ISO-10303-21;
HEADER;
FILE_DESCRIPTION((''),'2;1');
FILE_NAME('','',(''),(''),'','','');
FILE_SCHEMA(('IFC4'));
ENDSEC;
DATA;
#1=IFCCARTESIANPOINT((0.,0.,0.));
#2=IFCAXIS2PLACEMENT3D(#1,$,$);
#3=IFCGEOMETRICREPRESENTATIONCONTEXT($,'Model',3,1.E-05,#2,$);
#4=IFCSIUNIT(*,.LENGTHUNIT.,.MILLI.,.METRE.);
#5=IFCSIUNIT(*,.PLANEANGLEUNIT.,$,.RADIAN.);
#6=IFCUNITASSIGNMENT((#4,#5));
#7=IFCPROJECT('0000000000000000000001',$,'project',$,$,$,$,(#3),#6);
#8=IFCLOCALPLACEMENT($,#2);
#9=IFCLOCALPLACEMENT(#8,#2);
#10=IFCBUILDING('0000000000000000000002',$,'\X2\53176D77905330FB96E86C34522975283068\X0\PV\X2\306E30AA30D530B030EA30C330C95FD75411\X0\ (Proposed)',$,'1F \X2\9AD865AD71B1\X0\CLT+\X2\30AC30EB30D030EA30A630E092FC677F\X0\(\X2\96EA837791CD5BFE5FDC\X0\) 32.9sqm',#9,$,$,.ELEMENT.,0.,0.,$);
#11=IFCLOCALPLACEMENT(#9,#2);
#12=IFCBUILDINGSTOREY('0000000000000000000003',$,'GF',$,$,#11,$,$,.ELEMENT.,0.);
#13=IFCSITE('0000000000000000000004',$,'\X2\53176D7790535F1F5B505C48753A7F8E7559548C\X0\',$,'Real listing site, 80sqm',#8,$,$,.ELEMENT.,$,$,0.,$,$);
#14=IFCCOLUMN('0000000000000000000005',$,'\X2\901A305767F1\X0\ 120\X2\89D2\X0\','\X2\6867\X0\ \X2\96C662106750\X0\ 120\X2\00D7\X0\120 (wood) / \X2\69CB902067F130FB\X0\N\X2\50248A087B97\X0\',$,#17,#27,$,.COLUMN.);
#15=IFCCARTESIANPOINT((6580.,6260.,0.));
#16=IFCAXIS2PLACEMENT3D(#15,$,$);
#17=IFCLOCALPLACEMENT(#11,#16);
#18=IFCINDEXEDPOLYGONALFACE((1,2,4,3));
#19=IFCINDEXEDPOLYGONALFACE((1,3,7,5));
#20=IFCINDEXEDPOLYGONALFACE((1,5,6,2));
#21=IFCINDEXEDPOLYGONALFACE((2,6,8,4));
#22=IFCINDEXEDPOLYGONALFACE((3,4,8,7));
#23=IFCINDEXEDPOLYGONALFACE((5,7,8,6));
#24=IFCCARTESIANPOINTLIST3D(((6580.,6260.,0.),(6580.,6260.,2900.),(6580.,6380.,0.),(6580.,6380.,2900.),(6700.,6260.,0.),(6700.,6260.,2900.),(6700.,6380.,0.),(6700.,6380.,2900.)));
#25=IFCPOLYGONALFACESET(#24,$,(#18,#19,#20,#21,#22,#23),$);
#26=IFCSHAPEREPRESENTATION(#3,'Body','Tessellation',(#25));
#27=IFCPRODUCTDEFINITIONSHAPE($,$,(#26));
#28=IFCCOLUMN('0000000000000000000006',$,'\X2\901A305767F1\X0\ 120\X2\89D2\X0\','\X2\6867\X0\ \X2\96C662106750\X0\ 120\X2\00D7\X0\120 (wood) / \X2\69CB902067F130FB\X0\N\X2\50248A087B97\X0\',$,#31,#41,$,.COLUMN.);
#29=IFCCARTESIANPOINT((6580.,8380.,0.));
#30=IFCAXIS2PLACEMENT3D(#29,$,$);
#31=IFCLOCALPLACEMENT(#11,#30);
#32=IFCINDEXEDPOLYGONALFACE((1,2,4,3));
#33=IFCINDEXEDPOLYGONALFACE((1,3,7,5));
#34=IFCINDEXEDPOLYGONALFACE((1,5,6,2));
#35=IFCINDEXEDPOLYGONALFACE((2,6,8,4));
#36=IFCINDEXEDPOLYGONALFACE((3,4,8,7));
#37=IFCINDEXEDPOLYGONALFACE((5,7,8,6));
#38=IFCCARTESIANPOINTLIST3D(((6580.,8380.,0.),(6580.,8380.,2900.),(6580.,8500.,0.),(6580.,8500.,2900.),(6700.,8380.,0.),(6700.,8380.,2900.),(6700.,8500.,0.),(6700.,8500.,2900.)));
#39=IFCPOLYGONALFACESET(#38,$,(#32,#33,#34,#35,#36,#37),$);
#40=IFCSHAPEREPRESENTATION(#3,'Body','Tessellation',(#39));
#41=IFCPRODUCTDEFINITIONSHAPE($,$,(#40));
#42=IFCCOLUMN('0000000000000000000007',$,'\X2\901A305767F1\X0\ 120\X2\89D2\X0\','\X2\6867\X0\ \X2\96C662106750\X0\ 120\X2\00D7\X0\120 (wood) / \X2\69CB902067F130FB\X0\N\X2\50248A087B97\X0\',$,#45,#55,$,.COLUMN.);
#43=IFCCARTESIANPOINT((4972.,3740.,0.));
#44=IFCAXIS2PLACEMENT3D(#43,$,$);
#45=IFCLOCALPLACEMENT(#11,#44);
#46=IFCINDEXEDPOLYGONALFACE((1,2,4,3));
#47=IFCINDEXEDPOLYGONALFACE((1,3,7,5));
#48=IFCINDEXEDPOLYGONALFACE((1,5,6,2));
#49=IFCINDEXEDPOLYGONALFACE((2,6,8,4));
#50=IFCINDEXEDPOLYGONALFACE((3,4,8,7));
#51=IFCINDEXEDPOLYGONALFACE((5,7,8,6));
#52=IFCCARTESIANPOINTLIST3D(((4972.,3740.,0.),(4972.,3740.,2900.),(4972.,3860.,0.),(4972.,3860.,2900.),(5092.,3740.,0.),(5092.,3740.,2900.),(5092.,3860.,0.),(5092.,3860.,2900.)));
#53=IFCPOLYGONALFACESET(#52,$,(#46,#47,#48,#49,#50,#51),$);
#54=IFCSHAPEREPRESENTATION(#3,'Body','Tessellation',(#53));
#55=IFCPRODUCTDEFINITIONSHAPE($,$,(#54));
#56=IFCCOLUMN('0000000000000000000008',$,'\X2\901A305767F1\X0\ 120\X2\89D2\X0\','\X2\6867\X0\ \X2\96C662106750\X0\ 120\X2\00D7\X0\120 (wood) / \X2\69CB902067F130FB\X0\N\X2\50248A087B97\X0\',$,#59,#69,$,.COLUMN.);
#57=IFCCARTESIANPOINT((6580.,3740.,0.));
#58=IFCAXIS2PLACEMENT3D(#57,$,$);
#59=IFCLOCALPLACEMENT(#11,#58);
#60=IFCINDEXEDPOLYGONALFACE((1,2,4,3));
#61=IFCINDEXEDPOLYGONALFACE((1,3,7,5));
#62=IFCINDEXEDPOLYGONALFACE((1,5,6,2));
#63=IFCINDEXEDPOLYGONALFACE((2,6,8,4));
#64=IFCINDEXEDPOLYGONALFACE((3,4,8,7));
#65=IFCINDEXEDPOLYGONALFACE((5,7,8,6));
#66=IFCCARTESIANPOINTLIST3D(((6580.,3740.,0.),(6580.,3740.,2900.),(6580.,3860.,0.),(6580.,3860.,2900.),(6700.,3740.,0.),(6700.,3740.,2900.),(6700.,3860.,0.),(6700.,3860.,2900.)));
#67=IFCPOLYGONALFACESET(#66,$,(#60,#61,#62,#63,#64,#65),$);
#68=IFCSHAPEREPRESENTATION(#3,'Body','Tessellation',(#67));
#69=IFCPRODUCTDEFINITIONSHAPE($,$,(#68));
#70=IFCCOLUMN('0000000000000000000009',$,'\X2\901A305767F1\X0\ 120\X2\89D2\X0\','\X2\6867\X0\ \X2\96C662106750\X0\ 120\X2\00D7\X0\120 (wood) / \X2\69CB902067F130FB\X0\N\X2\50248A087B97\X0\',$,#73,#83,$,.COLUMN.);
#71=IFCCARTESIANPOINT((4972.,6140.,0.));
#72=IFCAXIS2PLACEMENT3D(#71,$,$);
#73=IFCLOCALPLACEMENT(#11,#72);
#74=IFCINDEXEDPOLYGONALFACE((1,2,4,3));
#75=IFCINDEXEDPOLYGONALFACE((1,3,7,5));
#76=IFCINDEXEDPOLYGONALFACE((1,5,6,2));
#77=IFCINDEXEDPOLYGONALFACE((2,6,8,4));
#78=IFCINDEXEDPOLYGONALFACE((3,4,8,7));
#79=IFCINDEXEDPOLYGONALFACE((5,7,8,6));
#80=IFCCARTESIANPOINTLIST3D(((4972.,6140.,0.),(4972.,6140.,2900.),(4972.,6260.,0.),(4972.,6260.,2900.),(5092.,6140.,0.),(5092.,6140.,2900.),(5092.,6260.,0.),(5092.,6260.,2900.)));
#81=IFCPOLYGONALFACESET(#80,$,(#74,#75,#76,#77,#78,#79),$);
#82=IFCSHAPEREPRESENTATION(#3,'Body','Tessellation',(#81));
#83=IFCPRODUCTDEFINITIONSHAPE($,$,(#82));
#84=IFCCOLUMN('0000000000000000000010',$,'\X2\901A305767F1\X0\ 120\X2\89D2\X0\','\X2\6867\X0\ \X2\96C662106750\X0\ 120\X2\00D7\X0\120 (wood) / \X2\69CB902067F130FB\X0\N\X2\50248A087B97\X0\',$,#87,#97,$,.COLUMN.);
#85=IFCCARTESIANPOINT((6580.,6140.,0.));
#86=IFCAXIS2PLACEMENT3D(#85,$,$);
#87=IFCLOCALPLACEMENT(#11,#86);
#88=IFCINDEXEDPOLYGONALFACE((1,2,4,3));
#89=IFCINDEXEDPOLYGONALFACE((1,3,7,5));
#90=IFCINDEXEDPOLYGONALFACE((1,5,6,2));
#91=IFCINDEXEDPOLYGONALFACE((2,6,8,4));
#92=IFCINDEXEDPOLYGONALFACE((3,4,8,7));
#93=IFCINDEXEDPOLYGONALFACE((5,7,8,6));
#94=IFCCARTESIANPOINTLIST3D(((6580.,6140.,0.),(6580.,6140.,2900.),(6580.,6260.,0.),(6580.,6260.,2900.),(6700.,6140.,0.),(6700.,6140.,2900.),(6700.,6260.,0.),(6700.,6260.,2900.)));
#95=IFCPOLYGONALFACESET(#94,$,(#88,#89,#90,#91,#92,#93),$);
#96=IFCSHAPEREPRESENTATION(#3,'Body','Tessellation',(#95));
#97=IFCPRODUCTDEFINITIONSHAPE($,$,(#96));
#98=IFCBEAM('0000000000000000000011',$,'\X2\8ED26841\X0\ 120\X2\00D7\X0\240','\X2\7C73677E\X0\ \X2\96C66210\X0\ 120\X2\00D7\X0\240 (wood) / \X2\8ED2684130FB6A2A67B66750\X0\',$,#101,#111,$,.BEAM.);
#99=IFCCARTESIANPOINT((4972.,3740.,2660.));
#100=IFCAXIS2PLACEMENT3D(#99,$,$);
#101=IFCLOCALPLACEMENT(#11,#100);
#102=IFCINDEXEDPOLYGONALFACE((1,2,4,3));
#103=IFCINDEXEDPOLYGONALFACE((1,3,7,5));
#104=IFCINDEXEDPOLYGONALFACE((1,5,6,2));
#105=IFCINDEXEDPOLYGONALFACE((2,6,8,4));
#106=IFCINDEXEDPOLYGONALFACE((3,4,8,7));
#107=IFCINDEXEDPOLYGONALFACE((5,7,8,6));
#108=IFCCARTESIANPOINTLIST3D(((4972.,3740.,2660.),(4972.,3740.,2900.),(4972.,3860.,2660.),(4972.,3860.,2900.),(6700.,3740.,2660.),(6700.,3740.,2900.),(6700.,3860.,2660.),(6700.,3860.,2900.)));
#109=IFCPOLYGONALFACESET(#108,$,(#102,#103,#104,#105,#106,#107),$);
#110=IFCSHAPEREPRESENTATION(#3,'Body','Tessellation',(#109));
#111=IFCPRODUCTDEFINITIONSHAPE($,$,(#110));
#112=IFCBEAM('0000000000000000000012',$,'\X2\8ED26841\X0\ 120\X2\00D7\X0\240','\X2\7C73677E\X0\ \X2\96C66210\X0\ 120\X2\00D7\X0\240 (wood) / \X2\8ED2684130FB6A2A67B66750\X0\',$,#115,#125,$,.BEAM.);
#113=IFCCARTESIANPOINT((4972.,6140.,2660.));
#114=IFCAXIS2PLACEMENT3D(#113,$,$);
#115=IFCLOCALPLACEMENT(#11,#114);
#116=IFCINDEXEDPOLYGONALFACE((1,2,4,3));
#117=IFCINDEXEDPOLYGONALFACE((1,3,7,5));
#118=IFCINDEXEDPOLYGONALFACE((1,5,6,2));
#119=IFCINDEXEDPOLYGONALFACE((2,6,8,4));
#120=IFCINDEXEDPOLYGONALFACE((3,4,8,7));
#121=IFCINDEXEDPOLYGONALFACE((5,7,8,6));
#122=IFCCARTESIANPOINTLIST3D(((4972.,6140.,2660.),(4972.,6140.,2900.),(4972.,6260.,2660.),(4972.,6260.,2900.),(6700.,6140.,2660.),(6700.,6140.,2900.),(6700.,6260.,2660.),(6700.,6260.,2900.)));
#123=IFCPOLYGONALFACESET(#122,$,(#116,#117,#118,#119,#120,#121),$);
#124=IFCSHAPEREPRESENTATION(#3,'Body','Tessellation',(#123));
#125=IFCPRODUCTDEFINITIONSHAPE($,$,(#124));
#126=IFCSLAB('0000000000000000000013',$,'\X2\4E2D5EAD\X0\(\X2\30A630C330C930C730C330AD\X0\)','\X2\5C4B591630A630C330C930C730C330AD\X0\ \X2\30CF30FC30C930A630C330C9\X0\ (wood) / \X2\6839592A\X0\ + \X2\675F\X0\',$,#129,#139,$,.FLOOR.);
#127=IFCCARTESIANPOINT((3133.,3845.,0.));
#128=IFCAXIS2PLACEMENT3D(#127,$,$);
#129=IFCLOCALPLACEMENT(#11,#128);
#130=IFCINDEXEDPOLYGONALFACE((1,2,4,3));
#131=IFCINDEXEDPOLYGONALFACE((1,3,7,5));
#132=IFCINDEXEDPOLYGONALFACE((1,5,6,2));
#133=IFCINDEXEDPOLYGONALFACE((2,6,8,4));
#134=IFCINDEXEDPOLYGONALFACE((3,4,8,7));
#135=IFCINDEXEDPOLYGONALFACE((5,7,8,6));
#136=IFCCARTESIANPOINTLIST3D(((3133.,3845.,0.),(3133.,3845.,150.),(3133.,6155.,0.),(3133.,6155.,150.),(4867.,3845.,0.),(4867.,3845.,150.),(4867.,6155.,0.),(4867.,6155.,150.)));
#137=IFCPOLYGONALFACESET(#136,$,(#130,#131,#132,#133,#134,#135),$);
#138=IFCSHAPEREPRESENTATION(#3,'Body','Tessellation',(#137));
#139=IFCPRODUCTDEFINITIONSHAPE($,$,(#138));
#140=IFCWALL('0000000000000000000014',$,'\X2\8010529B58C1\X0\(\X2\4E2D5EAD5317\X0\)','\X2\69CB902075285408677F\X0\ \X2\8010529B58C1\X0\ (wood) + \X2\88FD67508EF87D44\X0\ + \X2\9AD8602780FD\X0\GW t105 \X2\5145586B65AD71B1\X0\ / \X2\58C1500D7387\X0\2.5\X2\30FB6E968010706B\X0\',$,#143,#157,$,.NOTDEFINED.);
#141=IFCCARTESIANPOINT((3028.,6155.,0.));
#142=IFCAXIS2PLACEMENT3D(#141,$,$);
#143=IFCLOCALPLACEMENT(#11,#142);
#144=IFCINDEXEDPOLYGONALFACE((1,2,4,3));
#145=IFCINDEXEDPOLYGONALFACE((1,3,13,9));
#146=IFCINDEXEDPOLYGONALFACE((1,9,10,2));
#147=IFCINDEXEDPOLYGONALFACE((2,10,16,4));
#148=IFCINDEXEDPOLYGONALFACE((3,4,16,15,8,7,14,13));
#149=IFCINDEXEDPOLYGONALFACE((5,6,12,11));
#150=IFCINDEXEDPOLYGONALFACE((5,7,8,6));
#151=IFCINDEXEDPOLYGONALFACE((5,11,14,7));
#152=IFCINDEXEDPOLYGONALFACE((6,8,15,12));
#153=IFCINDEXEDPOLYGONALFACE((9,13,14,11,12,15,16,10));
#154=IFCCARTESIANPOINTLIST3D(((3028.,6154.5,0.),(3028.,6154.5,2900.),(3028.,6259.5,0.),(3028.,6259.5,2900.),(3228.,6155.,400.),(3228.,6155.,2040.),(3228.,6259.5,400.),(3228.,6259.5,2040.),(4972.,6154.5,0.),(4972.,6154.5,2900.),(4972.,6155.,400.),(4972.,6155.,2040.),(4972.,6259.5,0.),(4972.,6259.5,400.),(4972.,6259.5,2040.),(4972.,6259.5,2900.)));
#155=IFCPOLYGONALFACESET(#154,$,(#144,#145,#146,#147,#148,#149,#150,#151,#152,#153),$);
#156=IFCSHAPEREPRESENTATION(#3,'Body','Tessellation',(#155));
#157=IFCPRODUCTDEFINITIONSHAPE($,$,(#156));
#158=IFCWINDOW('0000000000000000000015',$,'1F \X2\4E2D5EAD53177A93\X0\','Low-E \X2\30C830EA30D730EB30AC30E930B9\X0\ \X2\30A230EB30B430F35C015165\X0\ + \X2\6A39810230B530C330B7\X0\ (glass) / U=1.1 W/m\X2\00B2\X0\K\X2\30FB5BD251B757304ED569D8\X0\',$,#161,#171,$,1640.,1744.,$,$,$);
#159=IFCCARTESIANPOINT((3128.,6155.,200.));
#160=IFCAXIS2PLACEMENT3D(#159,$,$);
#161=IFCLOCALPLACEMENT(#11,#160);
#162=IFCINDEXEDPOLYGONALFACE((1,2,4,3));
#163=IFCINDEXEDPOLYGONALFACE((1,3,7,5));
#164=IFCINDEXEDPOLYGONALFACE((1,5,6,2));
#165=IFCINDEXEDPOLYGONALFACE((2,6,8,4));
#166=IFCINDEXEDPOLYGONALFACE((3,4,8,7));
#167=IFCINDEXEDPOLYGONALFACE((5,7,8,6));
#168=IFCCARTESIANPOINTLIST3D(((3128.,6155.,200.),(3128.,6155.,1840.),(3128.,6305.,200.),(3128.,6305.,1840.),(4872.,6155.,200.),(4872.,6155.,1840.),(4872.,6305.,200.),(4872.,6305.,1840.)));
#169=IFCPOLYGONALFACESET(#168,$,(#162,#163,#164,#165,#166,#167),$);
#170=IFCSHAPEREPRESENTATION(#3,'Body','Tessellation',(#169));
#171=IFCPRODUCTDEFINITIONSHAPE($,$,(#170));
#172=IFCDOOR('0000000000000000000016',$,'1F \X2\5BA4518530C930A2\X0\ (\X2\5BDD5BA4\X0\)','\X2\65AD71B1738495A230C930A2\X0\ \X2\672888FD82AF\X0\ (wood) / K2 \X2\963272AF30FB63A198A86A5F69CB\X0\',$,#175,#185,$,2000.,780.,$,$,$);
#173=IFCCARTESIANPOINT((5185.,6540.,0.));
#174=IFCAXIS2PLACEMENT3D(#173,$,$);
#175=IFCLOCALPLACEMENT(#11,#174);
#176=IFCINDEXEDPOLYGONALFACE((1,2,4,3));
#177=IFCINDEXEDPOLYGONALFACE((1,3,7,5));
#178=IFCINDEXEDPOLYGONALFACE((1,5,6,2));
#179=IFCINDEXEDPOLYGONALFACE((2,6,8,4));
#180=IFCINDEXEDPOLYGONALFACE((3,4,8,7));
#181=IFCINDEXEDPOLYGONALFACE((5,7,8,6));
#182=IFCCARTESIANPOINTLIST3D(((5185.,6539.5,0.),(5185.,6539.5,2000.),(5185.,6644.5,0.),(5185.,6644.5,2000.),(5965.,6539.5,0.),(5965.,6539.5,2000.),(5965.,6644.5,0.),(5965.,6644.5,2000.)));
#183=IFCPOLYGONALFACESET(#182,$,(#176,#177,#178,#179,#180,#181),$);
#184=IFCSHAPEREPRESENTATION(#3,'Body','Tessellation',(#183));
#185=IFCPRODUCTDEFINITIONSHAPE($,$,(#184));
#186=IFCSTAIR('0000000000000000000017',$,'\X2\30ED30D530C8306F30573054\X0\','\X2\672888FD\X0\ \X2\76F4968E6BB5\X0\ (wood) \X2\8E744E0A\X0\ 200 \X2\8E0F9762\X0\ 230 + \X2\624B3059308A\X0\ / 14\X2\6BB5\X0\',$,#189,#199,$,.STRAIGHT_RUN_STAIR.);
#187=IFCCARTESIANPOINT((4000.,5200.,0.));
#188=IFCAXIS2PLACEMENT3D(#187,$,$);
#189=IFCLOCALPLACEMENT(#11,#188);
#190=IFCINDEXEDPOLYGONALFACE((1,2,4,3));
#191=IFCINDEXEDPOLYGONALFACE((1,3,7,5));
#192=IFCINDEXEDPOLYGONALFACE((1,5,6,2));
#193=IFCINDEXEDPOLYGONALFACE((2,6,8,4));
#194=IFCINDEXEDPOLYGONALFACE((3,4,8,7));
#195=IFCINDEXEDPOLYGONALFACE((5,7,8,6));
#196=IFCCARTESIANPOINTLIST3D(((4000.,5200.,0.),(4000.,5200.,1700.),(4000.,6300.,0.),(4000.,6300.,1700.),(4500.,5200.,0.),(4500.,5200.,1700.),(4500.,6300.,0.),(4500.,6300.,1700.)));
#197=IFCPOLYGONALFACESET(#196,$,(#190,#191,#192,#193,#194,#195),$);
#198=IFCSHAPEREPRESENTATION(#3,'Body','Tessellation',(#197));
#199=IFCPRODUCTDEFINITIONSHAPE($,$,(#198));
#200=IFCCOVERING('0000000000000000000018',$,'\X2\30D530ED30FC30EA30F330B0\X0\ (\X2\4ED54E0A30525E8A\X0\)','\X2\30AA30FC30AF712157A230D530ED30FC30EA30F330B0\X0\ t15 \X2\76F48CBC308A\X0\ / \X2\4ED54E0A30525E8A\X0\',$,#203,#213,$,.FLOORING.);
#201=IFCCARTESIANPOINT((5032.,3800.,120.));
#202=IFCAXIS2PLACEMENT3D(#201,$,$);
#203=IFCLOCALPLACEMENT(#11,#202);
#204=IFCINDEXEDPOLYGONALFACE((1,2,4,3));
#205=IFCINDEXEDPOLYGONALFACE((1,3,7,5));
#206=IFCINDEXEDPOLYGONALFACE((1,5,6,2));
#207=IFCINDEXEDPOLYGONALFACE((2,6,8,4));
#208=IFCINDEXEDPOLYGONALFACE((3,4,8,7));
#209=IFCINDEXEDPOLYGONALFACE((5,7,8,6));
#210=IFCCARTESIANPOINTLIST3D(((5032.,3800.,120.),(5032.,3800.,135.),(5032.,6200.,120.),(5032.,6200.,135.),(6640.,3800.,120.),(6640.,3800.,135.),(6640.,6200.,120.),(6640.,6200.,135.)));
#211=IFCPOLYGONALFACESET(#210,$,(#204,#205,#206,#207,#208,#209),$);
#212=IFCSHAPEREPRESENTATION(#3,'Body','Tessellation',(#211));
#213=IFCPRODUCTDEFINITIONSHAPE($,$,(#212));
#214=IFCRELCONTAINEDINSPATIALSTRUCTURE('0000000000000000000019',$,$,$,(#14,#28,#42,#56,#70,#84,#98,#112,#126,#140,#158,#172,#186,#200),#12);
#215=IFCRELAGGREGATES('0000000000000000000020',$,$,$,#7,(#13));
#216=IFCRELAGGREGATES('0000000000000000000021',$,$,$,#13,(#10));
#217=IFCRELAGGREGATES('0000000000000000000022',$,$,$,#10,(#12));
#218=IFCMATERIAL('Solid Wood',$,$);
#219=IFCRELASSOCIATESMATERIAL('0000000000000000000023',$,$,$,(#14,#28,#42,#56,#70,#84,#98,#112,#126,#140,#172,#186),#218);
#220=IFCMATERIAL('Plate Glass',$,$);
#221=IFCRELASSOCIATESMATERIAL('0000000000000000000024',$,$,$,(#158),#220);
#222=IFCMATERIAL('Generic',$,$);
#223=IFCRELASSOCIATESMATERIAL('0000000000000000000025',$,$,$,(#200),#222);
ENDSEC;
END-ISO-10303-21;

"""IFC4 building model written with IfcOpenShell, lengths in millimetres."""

from ifc_helpers import new_model, si_unit, frame, frame_2d, origin, place, context, project, spatial, rectangle, extrude, material, element, fill, save


model = new_model("IFC4")

# Units and contexts
model_context = context("Model", 3, precision=1e-05, world=origin())
ifc_project = project(units=[si_unit("LENGTHUNIT", "METRE", prefix="MILLI"), si_unit("PLANEANGLEUNIT", "RADIAN")], contexts=[model_context])

# Site, building, storey
site_placement = place(None, origin())
site = spatial("IfcSite", under=ifc_project, at=site_placement, Name="北海道弟子屈町美留和", ObjectType="Real listing site, 80sqm", CompositionType="ELEMENT", RefElevation=0.0)
building_placement = place(site_placement, origin())
building = spatial("IfcBuilding", under=site, at=building_placement, Name="北海道・雨水利用とPVのオフグリッド志向 (Proposed)", ObjectType="1F 高断熱CLT+ガルバリウム鋼板(雪荷重対応) 32.9sqm", CompositionType="ELEMENT", ElevationOfRefHeight=0.0, ElevationOfTerrain=0.0)
storey_placement = place(building_placement, origin())
storey = spatial("IfcBuildingStorey", under=building, at=storey_placement, Name="GF", CompositionType="ELEMENT", Elevation=0.0)

# Columns
ifc_material_1 = material(Name="Solid Wood")
column_1_placement = place(storey_placement, frame((6580.0, 6260.0, 0.0)))
element("IfcColumn", 1, at=column_1_placement, inside=storey, material=ifc_material_1, Name="通し柱 120角", Description="桧 集成材 120×120 (wood) / 構造柱・N値計算", PredefinedType="COLUMN", context=model_context, shape_type="SweptSolid", body=[
    extrude(rectangle(XDim=120.0, YDim=120.0, at=frame_2d((60.0, 60.0))), frame((6580.0, 6260.0, 0.0)), (0.0, 0.0, 1.0), 2900.0),
])
column_2_placement = place(storey_placement, frame((6580.0, 8380.0, 0.0)))
element("IfcColumn", 2, at=column_2_placement, inside=storey, material=ifc_material_1, Name="通し柱 120角", Description="桧 集成材 120×120 (wood) / 構造柱・N値計算", PredefinedType="COLUMN", context=model_context, shape_type="SweptSolid", body=[
    extrude(rectangle(XDim=120.0, YDim=120.0, at=frame_2d((60.0, 60.0))), frame((6580.0, 8380.0, 0.0)), (0.0, 0.0, 1.0), 2900.0),
])
column_3_placement = place(storey_placement, frame((4972.0, 3740.0, 0.0)))
element("IfcColumn", 3, at=column_3_placement, inside=storey, material=ifc_material_1, Name="通し柱 120角", Description="桧 集成材 120×120 (wood) / 構造柱・N値計算", PredefinedType="COLUMN", context=model_context, shape_type="SweptSolid", body=[
    extrude(rectangle(XDim=120.0, YDim=120.0, at=frame_2d((60.0, 60.0))), frame((4972.0, 3740.0, 0.0)), (0.0, 0.0, 1.0), 2900.0),
])
column_4_placement = place(storey_placement, frame((6580.0, 3740.0, 0.0)))
element("IfcColumn", 4, at=column_4_placement, inside=storey, material=ifc_material_1, Name="通し柱 120角", Description="桧 集成材 120×120 (wood) / 構造柱・N値計算", PredefinedType="COLUMN", context=model_context, shape_type="SweptSolid", body=[
    extrude(rectangle(XDim=120.0, YDim=120.0, at=frame_2d((60.0, 60.0))), frame((6580.0, 3740.0, 0.0)), (0.0, 0.0, 1.0), 2900.0),
])
column_5_placement = place(storey_placement, frame((4972.0, 6140.0, 0.0)))
element("IfcColumn", 5, at=column_5_placement, inside=storey, material=ifc_material_1, Name="通し柱 120角", Description="桧 集成材 120×120 (wood) / 構造柱・N値計算", PredefinedType="COLUMN", context=model_context, shape_type="SweptSolid", body=[
    extrude(rectangle(XDim=120.0, YDim=120.0, at=frame_2d((60.0, 60.0))), frame((4972.0, 6140.0, 0.0)), (0.0, 0.0, 1.0), 2900.0),
])
column_6_placement = place(storey_placement, frame((6580.0, 6140.0, 0.0)))
element("IfcColumn", 6, at=column_6_placement, inside=storey, material=ifc_material_1, Name="通し柱 120角", Description="桧 集成材 120×120 (wood) / 構造柱・N値計算", PredefinedType="COLUMN", context=model_context, shape_type="SweptSolid", body=[
    extrude(rectangle(XDim=120.0, YDim=120.0, at=frame_2d((60.0, 60.0))), frame((6580.0, 6140.0, 0.0)), (0.0, 0.0, 1.0), 2900.0),
])

# Beams
beam_1_placement = place(storey_placement, frame((4972.0, 3740.0, 2660.0)))
element("IfcBeam", 7, at=beam_1_placement, inside=storey, material=ifc_material_1, Name="軒桁 120×240", Description="米松 集成 120×240 (wood) / 軒桁・横架材", PredefinedType="BEAM", context=model_context, shape_type="SweptSolid", body=[
    extrude(rectangle(XDim=1728.0, YDim=120.0, at=frame_2d((864.0, 60.0))), frame((4972.0, 3740.0, 2660.0)), (0.0, 0.0, 1.0), 240.0),
])
beam_2_placement = place(storey_placement, frame((4972.0, 6140.0, 2660.0)))
element("IfcBeam", 8, at=beam_2_placement, inside=storey, material=ifc_material_1, Name="軒桁 120×240", Description="米松 集成 120×240 (wood) / 軒桁・横架材", PredefinedType="BEAM", context=model_context, shape_type="SweptSolid", body=[
    extrude(rectangle(XDim=1728.0, YDim=120.0, at=frame_2d((864.0, 60.0))), frame((4972.0, 6140.0, 2660.0)), (0.0, 0.0, 1.0), 240.0),
])

# Slab
slab_placement = place(storey_placement, frame((3133.0, 3845.0, 0.0)))
element("IfcSlab", 9, at=slab_placement, inside=storey, material=ifc_material_1, Name="中庭(ウッドデッキ)", Description="屋外ウッドデッキ ハードウッド (wood) / 根太 + 束", PredefinedType="FLOOR", context=model_context, shape_type="SweptSolid", body=[
    extrude(rectangle(XDim=1734.0, YDim=2310.0, at=frame_2d((867.0, 1155.0))), frame((3133.0, 3845.0, 0.0)), (0.0, 0.0, 1.0), 150.0),
])

# Wall, opening, window
wall_1_placement = place(storey_placement, frame((3028.0, 6155.0, 0.0)))
wall_1 = element("IfcWall", 10, at=wall_1_placement, inside=storey, material=ifc_material_1, Name="耐力壁(中庭北)", Description="構造用合板 耐力壁 (wood) + 製材軸組 + 高性能GW t105 充填断熱 / 壁倍率2.5・準耐火", PredefinedType="NOTDEFINED", context=model_context, shape_type="SweptSolid", body=[
    extrude(rectangle(XDim=1944.0, YDim=105.0, at=frame_2d((972.0, 52.0))), frame((3028.0, 6155.0, 0.0)), (0.0, 0.0, 1.0), 2900.0),
])
opening_placement = place(storey_placement, frame((3128.0, 6155.0, 200.0)))
opening = element("IfcOpeningElement", 11, at=opening_placement, cuts=wall_1, PredefinedType="NOTDEFINED", context=model_context, shape_type="SweptSolid", body=[
    extrude(rectangle(XDim=1744.0, YDim=150.0, at=frame_2d((872.0, 75.0))), frame((3128.0, 6155.0, 200.0)), (0.0, 0.0, 1.0), 1640.0),
])
ifc_material_2 = material(Name="Plate Glass")
window_placement = place(storey_placement, frame((3128.0, 6155.0, 200.0)))
window = element("IfcWindow", 12, at=window_placement, inside=storey, material=ifc_material_2, Name="1F 中庭北窓", Description="Low-E トリプルガラス アルゴン封入 + 樹脂サッシ (glass) / U=1.1 W/m²K・寒冷地仕様", OverallHeight=1640.0, OverallWidth=1744.0, context=model_context, shape_type="SweptSolid", body=[
    extrude(rectangle(XDim=1744.0, YDim=150.0, at=frame_2d((872.0, 75.0))), frame((3128.0, 6155.0, 200.0)), (0.0, 0.0, 1.0), 1640.0),
])
fill(opening, window)

# Door
door_placement = place(storey_placement, frame((5185.0, 6540.0, 0.0)))
element("IfcDoor", 13, at=door_placement, inside=storey, material=ifc_material_1, Name="1F 室内ドア (寝室)", Description="断熱玄関ドア 木製芯 (wood) / K2 防犯・採風機構", OverallHeight=2000.0, OverallWidth=780.0, context=model_context, shape_type="SweptSolid", body=[
    extrude(rectangle(XDim=780.0, YDim=105.0, at=frame_2d((390.0, 52.0))), frame((5185.0, 6540.0, 0.0)), (0.0, 0.0, 1.0), 2000.0),
])

# Stair
stair_placement = place(storey_placement, frame((4000.0, 5200.0, 0.0)))
element("IfcStair", 14, at=stair_placement, inside=storey, material=ifc_material_1, Name="ロフトはしご", Description="木製 直階段 (wood) 蹴上 200 踏面 230 + 手すり / 14段", PredefinedType="STRAIGHT_RUN_STAIR", context=model_context, shape_type="SweptSolid", body=[
    extrude(rectangle(XDim=500.0, YDim=1100.0, at=frame_2d((250.0, 550.0))), frame((4000.0, 5200.0, 0.0)), (0.0, 0.0, 1.0), 1700.0),
])

# Covering
ifc_material_3 = material(Name="Generic")
covering_placement = place(storey_placement, frame((5032.0, 3800.0, 120.0)))
element("IfcCovering", 15, at=covering_placement, inside=storey, material=ifc_material_3, Name="フローリング (仕上げ床)", Description="オーク無垢フローリング t15 直貼り / 仕上げ床", PredefinedType="FLOORING", context=model_context, shape_type="SweptSolid", body=[
    extrude(rectangle(XDim=1608.0, YDim=2400.0, at=frame_2d((804.0, 1200.0))), frame((5032.0, 3800.0, 120.0)), (0.0, 0.0, 1.0), 15.0),
])

save(model, "model.ifc")
